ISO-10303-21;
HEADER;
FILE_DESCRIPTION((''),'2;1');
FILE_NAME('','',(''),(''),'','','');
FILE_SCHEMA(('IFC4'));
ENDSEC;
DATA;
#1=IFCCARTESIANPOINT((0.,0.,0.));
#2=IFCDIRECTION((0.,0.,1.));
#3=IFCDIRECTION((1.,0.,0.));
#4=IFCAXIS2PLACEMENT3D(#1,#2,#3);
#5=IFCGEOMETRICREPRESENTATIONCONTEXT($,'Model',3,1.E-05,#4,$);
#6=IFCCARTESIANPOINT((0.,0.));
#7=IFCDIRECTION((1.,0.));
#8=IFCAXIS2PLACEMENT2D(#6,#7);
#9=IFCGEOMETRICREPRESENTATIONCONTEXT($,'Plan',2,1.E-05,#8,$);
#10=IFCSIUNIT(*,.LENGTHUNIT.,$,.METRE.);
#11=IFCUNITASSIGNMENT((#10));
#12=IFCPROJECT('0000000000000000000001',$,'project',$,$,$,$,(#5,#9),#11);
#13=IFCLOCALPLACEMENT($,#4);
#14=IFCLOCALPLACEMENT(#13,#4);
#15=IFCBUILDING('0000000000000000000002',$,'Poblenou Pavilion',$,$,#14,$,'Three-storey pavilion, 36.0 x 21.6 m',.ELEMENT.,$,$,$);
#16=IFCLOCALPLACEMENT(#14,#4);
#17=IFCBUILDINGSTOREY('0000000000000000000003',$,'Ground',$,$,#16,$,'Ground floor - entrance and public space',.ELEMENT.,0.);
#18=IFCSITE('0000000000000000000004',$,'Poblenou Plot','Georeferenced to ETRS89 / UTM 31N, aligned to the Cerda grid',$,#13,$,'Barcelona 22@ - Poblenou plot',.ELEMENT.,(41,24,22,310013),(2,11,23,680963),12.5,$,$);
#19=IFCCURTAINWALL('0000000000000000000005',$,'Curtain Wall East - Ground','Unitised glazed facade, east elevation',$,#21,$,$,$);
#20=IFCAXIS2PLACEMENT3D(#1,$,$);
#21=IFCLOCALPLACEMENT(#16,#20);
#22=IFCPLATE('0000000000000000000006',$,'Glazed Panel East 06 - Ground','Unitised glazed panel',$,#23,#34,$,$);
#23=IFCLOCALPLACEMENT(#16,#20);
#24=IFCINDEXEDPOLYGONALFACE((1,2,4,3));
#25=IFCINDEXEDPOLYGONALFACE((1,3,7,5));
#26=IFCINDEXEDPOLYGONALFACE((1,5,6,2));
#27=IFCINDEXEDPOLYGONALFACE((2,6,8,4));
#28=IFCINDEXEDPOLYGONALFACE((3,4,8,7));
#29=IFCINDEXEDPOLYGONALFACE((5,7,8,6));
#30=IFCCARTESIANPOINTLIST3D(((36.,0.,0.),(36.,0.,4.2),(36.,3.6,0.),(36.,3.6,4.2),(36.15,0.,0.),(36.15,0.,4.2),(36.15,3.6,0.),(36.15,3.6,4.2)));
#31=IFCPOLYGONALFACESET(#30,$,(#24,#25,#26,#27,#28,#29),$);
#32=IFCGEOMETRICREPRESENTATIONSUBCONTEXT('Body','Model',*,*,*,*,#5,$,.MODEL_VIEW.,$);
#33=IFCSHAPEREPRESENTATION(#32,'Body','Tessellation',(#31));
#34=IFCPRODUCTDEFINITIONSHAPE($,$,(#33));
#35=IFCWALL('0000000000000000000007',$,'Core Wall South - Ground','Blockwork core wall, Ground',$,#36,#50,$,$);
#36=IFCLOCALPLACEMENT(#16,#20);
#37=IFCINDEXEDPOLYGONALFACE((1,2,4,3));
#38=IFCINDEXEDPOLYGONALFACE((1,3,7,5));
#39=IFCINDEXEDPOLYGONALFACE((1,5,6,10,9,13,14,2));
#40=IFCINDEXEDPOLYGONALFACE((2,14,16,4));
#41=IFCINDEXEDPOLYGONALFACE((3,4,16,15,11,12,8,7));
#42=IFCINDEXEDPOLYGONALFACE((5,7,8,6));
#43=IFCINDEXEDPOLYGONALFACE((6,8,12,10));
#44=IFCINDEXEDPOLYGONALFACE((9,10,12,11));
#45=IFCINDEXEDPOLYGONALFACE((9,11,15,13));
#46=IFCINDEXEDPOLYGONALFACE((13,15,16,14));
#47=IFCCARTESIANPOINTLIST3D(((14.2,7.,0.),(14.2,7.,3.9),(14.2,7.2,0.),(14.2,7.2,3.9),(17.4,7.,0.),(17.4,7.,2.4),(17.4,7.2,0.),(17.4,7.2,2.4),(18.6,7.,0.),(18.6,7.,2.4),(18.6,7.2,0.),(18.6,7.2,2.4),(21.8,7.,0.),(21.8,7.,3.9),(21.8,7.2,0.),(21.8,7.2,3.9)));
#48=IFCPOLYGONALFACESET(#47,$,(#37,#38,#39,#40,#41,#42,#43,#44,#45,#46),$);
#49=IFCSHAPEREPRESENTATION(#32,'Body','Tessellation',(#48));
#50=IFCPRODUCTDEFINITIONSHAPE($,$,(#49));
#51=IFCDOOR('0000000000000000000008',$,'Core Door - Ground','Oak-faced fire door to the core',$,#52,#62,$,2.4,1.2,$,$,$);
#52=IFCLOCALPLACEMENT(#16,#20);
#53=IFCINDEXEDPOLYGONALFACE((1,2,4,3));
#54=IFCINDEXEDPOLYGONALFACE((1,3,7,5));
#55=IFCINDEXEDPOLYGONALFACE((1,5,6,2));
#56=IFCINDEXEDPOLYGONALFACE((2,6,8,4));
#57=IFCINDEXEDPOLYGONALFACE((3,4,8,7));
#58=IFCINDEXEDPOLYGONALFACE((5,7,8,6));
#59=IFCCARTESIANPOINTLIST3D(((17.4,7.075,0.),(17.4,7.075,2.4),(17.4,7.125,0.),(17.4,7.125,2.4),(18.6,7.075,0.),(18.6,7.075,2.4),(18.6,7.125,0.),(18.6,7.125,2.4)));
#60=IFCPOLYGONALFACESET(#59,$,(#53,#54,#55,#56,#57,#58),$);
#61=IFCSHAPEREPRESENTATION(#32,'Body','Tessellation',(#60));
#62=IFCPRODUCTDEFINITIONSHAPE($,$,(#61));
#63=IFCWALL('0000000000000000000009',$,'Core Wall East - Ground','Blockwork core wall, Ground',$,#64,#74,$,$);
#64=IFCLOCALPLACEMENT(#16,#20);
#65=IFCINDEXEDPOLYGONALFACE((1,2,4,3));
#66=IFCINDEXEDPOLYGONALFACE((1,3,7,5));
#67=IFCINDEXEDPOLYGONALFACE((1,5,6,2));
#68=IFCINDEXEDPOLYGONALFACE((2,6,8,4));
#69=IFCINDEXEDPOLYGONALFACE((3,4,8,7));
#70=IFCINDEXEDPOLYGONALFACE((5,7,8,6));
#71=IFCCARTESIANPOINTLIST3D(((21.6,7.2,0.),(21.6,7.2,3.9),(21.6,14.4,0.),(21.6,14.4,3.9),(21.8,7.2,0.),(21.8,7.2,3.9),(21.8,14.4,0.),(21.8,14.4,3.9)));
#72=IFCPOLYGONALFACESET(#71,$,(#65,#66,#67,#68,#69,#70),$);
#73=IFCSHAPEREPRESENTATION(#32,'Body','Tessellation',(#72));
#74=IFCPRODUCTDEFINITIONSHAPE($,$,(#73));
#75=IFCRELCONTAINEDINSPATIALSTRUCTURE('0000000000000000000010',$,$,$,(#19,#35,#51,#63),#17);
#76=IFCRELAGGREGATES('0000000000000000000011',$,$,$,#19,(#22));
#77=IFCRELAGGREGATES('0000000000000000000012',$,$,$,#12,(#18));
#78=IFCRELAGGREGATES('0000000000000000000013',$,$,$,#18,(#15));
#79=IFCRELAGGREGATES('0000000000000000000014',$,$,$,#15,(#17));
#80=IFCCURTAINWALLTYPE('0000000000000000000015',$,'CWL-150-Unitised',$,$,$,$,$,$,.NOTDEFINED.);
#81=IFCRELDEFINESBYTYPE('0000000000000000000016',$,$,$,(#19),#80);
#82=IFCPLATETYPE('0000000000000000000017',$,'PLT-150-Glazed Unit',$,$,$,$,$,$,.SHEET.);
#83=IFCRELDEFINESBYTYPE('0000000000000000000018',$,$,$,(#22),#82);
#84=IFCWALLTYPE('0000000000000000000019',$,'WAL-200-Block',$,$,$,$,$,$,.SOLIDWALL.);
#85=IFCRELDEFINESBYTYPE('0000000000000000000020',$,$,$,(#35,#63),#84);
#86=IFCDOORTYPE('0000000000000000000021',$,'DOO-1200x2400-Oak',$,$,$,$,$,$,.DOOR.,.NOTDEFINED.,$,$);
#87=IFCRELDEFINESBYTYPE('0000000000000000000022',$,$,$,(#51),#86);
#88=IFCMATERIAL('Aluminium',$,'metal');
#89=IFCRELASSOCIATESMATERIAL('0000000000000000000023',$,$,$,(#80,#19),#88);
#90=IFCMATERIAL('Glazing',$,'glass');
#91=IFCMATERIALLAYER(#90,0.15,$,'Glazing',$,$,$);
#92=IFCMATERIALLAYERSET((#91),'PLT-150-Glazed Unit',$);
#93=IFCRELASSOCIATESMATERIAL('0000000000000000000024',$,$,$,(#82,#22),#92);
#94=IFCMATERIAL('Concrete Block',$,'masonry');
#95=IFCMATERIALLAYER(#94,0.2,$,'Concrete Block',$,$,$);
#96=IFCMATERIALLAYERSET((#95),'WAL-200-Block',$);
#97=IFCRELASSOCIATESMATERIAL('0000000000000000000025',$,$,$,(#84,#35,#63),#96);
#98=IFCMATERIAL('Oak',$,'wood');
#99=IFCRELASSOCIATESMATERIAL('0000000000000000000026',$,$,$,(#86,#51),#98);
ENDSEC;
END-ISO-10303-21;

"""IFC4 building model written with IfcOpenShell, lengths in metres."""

from ifc_helpers import new_model, si_unit, frame, origin_with_axes, origin_2d_with_axis, place, context, subcontext, project, spatial, line, indexed_curve, outline, extrude, material, layer, layer_set, layer_usage, type_object, element, fill, aggregate, save


model = new_model("IFC4")

# Units and contexts
model_context = context("Model", 3, precision=1e-05, world=origin_with_axes())
plan_context = context("Plan", 2, precision=1e-05, world=origin_2d_with_axis())
body_context = subcontext(model_context, "Body", "Model", "MODEL_VIEW")
ifc_project = project(units=[si_unit("LENGTHUNIT", "METRE")], contexts=[model_context, plan_context])

# Site, building, storey
site_placement = place(None, origin_with_axes())
site = spatial("IfcSite", under=ifc_project, at=site_placement, Name="Poblenou Plot", Description="Georeferenced to ETRS89 / UTM 31N, aligned to the Cerda grid", LongName="Barcelona 22@ - Poblenou plot", CompositionType="ELEMENT", RefLatitude=(41, 24, 22, 310013), RefLongitude=(2, 11, 23, 680963), RefElevation=12.5)
building_placement = place(site_placement, origin_with_axes())
building = spatial("IfcBuilding", under=site, at=building_placement, Name="Poblenou Pavilion", LongName="Three-storey pavilion, 36.0 x 21.6 m", CompositionType="ELEMENT")
storey_placement = place(building_placement, origin_with_axes())
storey = spatial("IfcBuildingStorey", under=building, at=storey_placement, Name="Ground", LongName="Ground floor - entrance and public space", CompositionType="ELEMENT", Elevation=0.0)

# Curtain wall, plate
ifc_material_1 = material(Name="Aluminium", Category="metal")
curtain_wall_type = type_object("IfcCurtainWallType", Name="CWL-150-Unitised", PredefinedType="NOTDEFINED", material=ifc_material_1)
ifc_material_2 = material(Name="Glazing", Category="glass")
ifc_layer_1 = layer(ifc_material_2, 0.15, Name="Glazing")
ifc_layer_set_1 = layer_set([ifc_layer_1], Name="PLT-150-Glazed Unit")
plate_type = type_object("IfcPlateType", Name="PLT-150-Glazed Unit", PredefinedType="SHEET", material=ifc_layer_set_1)
curtain_wall_1_placement = place(storey_placement, frame((36.0, 21.6, 0.0), z_axis=(0.0, 0.0, 1.0), x_axis=(0.0, -1.0, 0.0)))
curtain_wall_1 = element("IfcCurtainWall", 1, at=curtain_wall_1_placement, inside=storey, type_object=curtain_wall_type, material=ifc_material_1, Name="Curtain Wall East - Ground", Description="Unitised glazed facade, east elevation")
ifc_layer_usage_1 = layer_usage(ifc_layer_set_1, "AXIS2", "POSITIVE", 0.0)
plate_1_placement = place(curtain_wall_1_placement, frame((18.0, 0.0, 0.0), z_axis=(0.0, 0.0, 1.0), x_axis=(1.0, 0.0, 0.0)))
plate_1 = element("IfcPlate", 2, at=plate_1_placement, type_object=plate_type, material=ifc_layer_usage_1, Name="Glazed Panel East 06 - Ground", Description="Unitised glazed panel", context=body_context, shape_type="SweptSolid", body=[
    extrude(outline(indexed_curve([(0.0, 0.0), (3.6, 0.0), (3.6, 0.15), (0.0, 0.15)], segments=[line(1, 2, 3, 4, 1)])), origin_with_axes(), (0.0, 0.0, 1.0), 4.2),
])
aggregate(curtain_wall_1, [plate_1])

# Wall, opening, door
ifc_material_3 = material(Name="Concrete Block", Category="masonry")
ifc_layer_2 = layer(ifc_material_3, 0.2, Name="Concrete Block")
ifc_layer_set_2 = layer_set([ifc_layer_2], Name="WAL-200-Block")
ifc_layer_usage_2 = layer_usage(ifc_layer_set_2, "AXIS2", "POSITIVE", 0.0)
wall_type = type_object("IfcWallType", Name="WAL-200-Block", PredefinedType="SOLIDWALL", material=ifc_layer_set_2)
wall_1_placement = place(storey_placement, frame((21.8, 7.2, 0.0), z_axis=(0.0, 0.0, 1.0), x_axis=(-1.0, 0.0, 0.0)))
wall_1 = element("IfcWall", 3, at=wall_1_placement, inside=storey, type_object=wall_type, material=ifc_layer_usage_2, Name="Core Wall South - Ground", Description="Blockwork core wall, Ground", context=body_context, shape_type="SweptSolid", body=[
    extrude(outline(indexed_curve([(0.0, 0.0), (7.6, 0.0), (7.6, 0.2), (0.0, 0.2)], segments=[line(1, 2, 3, 4, 1)])), origin_with_axes(), (0.0, 0.0, 1.0), 3.9),
])
opening_placement = place(wall_1_placement, frame((4.4, 0.21, 0.0), z_axis=(0.0, 0.0, 1.0), x_axis=(-1.0, 0.0, 0.0)))
opening = element("IfcOpeningElement", 4, at=opening_placement, cuts=wall_1, PredefinedType="OPENING", context=body_context, shape_type="SweptSolid", body=[
    extrude(outline(indexed_curve([(0.0, 0.0), (1.2, 0.0), (1.2, 0.22), (0.0, 0.22)], segments=[line(1, 2, 3, 4, 1)])), origin_with_axes(), (0.0, 0.0, 1.0), 2.4),
])
ifc_material_4 = material(Name="Oak", Category="wood")
door_type = type_object("IfcDoorType", Name="DOO-1200x2400-Oak", OperationType="NOTDEFINED", PredefinedType="DOOR", material=ifc_material_4)
door_placement = place(storey_placement, frame((17.4, 7.075, 0.0), z_axis=(0.0, 0.0, 1.0), x_axis=(1.0, 0.0, 0.0)))
door = element("IfcDoor", 5, at=door_placement, inside=storey, type_object=door_type, material=ifc_material_4, Name="Core Door - Ground", Description="Oak-faced fire door to the core", OverallHeight=2.4, OverallWidth=1.2, context=body_context, shape_type="SweptSolid", body=[
    extrude(outline(indexed_curve([(0.0, 0.0), (1.2, 0.0), (1.2, 0.05), (0.0, 0.05)], segments=[line(1, 2, 3, 4, 1)])), origin_with_axes(), (0.0, 0.0, 1.0), 2.4),
])
fill(opening, door)

# Wall
ifc_layer_usage_3 = layer_usage(ifc_layer_set_2, "AXIS2", "POSITIVE", 0.0)
wall_2_placement = place(storey_placement, frame((21.6, 14.4, 0.0), z_axis=(0.0, 0.0, 1.0), x_axis=(0.0, -1.0, 0.0)))
element("IfcWall", 6, at=wall_2_placement, inside=storey, type_object=wall_type, material=ifc_layer_usage_3, Name="Core Wall East - Ground", Description="Blockwork core wall, Ground", context=body_context, shape_type="SweptSolid", body=[
    extrude(outline(indexed_curve([(0.0, 0.0), (7.2, 0.0), (7.2, 0.2), (0.0, 0.2)], segments=[line(1, 2, 3, 4, 1)])), origin_with_axes(), (0.0, 0.0, 1.0), 3.9),
])

save(model, "model.ifc")
